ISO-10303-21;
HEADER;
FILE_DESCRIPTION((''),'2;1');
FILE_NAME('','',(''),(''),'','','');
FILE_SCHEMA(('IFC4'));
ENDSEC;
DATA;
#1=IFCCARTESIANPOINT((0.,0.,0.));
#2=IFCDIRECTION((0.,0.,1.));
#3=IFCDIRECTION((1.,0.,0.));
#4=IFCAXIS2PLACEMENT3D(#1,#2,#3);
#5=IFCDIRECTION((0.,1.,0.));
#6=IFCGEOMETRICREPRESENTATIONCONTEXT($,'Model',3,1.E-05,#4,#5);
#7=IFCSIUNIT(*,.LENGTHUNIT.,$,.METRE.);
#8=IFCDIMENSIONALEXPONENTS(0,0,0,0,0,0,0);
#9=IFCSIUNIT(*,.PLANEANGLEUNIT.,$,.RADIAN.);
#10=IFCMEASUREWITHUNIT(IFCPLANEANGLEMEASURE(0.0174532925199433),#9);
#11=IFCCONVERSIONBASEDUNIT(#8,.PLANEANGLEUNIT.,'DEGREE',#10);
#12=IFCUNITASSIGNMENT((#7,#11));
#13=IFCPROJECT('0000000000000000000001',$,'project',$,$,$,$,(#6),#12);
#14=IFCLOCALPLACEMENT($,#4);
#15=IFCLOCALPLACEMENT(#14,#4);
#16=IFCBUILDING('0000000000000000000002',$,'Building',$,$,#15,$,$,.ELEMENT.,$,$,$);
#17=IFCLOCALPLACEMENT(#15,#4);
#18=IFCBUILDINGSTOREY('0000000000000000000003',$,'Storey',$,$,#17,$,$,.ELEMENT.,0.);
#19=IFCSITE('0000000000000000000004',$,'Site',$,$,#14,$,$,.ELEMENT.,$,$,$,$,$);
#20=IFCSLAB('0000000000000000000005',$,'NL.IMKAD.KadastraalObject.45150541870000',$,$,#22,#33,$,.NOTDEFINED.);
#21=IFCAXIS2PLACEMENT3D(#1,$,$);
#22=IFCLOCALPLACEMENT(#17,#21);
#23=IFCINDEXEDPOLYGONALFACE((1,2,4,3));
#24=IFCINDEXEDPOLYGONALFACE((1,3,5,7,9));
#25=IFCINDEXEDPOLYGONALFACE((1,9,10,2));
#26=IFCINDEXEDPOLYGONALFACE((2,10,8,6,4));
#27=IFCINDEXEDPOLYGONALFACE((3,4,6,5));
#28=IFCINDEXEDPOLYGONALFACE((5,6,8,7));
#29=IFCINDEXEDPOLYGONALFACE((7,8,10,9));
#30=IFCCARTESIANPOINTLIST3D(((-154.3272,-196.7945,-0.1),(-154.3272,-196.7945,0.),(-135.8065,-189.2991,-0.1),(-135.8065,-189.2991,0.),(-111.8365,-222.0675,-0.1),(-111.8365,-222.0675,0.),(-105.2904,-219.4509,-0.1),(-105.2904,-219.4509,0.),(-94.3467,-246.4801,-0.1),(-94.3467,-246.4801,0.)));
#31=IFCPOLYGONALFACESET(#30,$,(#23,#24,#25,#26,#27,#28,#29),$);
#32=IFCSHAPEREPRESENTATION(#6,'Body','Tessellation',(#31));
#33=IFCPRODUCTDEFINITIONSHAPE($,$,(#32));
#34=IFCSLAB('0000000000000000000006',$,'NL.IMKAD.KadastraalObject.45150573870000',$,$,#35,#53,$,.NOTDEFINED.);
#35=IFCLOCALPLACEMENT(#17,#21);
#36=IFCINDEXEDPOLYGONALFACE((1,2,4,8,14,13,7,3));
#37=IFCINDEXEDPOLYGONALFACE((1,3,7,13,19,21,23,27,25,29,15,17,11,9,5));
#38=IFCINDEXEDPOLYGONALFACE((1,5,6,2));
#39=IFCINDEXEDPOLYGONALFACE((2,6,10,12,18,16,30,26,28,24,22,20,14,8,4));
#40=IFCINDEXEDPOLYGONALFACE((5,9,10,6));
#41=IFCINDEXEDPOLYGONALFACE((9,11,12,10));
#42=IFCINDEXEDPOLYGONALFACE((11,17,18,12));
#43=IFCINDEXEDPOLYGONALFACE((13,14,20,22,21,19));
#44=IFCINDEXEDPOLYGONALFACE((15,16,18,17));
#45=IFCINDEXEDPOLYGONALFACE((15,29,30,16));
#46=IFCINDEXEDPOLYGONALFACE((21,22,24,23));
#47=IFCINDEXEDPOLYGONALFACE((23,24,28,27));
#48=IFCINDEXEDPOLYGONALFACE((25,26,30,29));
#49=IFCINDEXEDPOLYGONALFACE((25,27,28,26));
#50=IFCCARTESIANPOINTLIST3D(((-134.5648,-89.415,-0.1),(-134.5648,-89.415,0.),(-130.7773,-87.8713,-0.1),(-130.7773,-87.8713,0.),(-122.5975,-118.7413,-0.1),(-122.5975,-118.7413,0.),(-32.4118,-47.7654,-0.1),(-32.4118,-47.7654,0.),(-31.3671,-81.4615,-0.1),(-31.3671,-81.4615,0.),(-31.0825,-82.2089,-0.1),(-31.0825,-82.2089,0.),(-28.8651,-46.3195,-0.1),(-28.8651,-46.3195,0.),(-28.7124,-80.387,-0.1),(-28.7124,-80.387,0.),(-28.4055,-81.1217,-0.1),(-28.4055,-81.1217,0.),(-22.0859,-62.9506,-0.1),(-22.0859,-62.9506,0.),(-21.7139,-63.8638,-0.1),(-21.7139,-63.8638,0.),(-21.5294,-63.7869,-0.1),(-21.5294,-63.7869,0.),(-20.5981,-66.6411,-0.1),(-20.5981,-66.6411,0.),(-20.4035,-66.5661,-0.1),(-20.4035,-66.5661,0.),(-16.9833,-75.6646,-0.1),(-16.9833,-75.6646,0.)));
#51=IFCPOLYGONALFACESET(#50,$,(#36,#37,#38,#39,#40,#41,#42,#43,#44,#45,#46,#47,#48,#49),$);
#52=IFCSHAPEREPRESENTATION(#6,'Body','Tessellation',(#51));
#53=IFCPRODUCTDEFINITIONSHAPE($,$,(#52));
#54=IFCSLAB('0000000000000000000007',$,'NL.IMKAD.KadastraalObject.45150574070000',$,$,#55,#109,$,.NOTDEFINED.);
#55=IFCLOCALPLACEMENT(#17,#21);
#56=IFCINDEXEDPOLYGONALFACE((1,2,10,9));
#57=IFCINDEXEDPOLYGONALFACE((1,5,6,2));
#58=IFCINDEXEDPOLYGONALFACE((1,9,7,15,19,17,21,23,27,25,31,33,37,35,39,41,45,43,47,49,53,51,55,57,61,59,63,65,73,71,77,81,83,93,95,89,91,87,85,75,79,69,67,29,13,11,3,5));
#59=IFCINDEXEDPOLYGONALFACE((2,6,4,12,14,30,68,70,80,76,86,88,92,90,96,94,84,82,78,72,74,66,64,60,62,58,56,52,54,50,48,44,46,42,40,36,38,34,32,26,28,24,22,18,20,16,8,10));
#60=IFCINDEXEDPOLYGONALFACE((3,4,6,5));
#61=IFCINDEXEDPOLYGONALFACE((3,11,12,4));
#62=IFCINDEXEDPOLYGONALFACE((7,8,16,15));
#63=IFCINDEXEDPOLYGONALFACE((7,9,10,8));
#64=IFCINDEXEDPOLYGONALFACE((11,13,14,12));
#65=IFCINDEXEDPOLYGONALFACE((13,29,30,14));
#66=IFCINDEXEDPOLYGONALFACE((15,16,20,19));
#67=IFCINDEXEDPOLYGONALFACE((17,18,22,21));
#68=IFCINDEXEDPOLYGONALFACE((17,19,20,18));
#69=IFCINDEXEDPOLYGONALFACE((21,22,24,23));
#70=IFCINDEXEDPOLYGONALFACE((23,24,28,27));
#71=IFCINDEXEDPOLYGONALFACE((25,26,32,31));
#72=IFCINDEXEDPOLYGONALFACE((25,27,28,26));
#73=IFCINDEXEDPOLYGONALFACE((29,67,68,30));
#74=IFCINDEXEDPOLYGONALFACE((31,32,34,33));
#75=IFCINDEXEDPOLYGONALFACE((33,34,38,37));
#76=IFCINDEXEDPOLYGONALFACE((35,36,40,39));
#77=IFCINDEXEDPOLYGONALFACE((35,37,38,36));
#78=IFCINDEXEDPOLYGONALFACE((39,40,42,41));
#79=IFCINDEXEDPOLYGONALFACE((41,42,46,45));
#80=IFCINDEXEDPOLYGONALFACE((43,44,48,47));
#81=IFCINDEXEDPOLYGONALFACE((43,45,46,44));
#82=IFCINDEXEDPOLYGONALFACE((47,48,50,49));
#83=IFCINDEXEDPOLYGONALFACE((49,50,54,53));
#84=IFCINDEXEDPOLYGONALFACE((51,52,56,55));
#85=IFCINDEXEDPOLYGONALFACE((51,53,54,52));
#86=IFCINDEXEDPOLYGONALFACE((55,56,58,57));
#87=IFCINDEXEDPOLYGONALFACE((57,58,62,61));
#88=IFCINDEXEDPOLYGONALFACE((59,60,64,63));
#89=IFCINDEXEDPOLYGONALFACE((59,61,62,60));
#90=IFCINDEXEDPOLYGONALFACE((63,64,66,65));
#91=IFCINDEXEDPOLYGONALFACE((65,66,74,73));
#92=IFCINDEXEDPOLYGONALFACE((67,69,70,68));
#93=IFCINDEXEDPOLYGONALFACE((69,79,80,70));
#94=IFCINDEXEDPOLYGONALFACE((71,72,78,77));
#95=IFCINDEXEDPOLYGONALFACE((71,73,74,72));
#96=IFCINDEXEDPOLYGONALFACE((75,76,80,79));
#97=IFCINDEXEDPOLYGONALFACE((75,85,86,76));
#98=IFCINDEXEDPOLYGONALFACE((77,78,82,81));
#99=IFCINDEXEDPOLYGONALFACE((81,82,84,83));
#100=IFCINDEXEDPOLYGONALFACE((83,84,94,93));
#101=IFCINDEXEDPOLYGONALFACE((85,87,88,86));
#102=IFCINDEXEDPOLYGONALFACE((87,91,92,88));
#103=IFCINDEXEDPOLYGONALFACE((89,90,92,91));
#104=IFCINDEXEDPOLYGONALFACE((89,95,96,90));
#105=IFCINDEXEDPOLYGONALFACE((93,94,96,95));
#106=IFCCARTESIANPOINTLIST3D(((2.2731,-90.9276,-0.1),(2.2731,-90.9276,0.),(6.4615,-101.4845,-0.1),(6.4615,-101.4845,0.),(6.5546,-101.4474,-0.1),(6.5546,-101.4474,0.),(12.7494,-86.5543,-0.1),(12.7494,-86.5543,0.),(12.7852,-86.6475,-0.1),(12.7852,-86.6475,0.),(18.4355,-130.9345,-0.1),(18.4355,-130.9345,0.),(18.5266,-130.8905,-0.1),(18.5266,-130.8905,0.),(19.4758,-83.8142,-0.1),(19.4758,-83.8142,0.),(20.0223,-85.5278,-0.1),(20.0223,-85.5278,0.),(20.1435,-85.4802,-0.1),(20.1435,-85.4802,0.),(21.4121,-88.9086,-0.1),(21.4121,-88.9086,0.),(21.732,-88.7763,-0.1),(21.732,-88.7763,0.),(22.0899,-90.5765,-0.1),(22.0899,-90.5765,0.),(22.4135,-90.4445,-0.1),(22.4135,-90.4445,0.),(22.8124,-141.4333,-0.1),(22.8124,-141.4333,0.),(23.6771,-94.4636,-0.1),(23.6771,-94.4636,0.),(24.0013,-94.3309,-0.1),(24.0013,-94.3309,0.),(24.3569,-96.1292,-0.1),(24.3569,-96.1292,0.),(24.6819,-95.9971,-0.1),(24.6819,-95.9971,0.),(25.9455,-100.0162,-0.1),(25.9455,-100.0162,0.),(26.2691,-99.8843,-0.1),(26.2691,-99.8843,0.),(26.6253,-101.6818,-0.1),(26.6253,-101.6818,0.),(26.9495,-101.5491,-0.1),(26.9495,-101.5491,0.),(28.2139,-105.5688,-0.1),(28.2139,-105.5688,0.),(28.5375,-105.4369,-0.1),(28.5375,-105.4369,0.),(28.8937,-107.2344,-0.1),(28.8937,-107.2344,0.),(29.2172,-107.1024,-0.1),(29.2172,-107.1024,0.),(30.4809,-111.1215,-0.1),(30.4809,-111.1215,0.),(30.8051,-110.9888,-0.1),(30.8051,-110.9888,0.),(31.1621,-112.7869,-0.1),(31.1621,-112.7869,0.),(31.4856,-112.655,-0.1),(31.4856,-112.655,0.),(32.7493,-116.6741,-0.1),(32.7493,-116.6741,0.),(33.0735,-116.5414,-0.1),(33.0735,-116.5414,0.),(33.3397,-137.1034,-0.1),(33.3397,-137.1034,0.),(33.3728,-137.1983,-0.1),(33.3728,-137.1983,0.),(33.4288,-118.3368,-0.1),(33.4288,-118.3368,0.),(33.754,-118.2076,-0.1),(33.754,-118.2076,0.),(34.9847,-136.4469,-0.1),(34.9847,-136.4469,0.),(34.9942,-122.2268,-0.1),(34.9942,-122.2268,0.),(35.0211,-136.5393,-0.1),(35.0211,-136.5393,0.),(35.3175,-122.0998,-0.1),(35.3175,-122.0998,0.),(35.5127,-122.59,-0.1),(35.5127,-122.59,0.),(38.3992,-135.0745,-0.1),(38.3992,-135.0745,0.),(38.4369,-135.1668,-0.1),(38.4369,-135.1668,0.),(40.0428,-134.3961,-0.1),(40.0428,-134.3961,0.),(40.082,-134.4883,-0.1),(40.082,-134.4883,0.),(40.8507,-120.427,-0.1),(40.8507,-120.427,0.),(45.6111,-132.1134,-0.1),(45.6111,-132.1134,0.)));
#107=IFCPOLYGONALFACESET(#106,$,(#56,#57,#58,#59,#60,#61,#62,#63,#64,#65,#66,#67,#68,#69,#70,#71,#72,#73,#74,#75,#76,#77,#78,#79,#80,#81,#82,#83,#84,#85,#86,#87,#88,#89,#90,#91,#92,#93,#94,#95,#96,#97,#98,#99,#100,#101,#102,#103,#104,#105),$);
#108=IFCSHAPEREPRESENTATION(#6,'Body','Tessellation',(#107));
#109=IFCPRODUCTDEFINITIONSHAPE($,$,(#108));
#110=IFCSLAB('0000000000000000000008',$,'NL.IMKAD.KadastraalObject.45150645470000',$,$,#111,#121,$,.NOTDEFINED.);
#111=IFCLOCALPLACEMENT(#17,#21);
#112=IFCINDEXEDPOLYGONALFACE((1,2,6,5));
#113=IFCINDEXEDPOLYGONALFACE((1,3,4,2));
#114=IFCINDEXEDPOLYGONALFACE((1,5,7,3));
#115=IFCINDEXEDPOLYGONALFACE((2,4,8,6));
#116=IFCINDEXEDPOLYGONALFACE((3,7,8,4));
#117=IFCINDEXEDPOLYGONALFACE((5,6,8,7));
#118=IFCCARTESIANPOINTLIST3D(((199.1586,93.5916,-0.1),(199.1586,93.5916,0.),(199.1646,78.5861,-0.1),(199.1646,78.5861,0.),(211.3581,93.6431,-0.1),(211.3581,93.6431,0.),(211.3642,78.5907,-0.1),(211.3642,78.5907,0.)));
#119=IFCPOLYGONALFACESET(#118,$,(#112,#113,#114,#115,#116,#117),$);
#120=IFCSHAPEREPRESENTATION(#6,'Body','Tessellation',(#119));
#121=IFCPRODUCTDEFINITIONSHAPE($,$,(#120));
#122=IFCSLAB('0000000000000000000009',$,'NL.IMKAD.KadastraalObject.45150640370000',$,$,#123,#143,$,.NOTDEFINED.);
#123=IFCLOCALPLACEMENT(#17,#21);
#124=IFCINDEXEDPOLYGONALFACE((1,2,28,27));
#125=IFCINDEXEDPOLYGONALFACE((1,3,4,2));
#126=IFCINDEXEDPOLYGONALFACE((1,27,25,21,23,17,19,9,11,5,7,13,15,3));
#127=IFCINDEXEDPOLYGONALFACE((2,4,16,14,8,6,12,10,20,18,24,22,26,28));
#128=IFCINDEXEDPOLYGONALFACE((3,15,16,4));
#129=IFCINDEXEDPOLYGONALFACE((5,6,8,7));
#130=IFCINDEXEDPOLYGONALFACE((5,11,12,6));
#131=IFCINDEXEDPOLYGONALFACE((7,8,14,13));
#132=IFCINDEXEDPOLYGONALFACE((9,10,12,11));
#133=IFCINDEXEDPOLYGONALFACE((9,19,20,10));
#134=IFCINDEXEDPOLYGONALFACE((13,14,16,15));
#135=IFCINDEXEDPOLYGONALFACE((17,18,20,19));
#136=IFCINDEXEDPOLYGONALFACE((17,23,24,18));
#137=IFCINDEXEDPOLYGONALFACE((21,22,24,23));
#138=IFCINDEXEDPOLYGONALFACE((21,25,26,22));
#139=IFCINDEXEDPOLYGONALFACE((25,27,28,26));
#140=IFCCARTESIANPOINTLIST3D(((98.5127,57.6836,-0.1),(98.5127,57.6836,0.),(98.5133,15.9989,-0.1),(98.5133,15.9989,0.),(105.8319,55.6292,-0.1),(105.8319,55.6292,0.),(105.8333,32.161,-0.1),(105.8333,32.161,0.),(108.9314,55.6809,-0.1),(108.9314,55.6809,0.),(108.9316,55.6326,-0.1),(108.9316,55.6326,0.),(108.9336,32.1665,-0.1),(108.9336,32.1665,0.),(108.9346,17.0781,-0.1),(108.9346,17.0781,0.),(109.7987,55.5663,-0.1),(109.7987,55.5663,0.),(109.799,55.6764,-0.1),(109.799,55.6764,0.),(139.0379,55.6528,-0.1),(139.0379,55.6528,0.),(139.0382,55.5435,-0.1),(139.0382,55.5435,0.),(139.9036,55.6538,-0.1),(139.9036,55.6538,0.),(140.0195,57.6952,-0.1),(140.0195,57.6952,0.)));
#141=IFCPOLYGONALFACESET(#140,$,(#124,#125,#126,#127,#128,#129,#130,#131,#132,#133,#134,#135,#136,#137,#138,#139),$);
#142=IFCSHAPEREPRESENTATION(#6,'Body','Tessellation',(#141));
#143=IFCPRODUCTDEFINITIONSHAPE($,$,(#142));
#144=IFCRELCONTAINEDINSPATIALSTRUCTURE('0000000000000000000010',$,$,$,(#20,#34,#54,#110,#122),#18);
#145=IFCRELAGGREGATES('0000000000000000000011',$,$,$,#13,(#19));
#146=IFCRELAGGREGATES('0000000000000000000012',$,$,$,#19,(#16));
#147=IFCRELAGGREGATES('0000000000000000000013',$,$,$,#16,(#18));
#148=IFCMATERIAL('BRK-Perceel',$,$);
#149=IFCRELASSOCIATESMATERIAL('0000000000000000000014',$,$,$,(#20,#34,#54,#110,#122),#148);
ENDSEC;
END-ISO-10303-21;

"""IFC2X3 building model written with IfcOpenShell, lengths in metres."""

from ifc_helpers import new_model, entity, si_unit, converted_unit, direction, frame, origin_with_axes, place, context, project, spatial, polyline, outline, extrude, material, element, save


model = new_model("IFC2X3")

# Units and contexts
model_context = context("Model", 3, precision=1e-05, world=origin_with_axes(), true_north=direction((0.0, 1.0, 0.0)))
ifc_project = project(units=[si_unit("LENGTHUNIT", "METRE"), converted_unit("PLANEANGLEUNIT", "DEGREE", entity("IfcPlaneAngleMeasure", 0.0174532925199433), si_unit("PLANEANGLEUNIT", "RADIAN"), dimensions=[0, 0, 0, 0, 0, 0, 0])], contexts=[model_context])

# Site, building, storey
site_placement = place(None, origin_with_axes())
site = spatial("IfcSite", under=ifc_project, at=site_placement, Name="Site", CompositionType="ELEMENT")
building_placement = place(site_placement, origin_with_axes())
building = spatial("IfcBuilding", under=site, at=building_placement, Name="Building", CompositionType="ELEMENT")
storey_placement = place(building_placement, origin_with_axes())
storey = spatial("IfcBuildingStorey", under=building, at=storey_placement, Name="Storey", CompositionType="ELEMENT", Elevation=0.0)

# Slabs
ifc_material = material(Name="BRK-Perceel")
slab_1_placement = place(storey_placement, frame((0.0, 0.0, -0.1), z_axis=(0.0, 0.0, 1.0), x_axis=(1.0, 0.0, 0.0)))
element("IfcSlab", 1, at=slab_1_placement, inside=storey, material=ifc_material, Name="NL.IMKAD.KadastraalObject.45150541870000", PredefinedType="NOTDEFINED", context=model_context, shape_type="SweptSolid", body=[
    extrude(outline(polyline([(-135.8065, -189.2991), (-111.8365, -222.0675), (-105.2904, -219.4509), (-94.3467, -246.4801), (-154.3272, -196.7945), (-135.8065, -189.2991)])), origin_with_axes(), (0.0, 0.0, 1.0), 0.1),
])
slab_2_placement = place(storey_placement, frame((0.0, 0.0, -0.1), z_axis=(0.0, 0.0, 1.0), x_axis=(1.0, 0.0, 0.0)))
element("IfcSlab", 2, at=slab_2_placement, inside=storey, material=ifc_material, Name="NL.IMKAD.KadastraalObject.45150573870000", PredefinedType="NOTDEFINED", context=model_context, shape_type="SweptSolid", body=[
    extrude(outline(polyline([(-22.0859, -62.9506), (-21.7139, -63.8638), (-21.5294, -63.7869), (-20.4035, -66.5661), (-20.5981, -66.6411), (-16.9833, -75.6646), (-28.7124, -80.387), (-28.4055, -81.1217), (-31.0825, -82.2089), (-31.3671, -81.4615), (-122.5975, -118.7413), (-134.5648, -89.415), (-130.7773, -87.8713), (-32.4118, -47.7654), (-28.8651, -46.3195), (-22.0859, -62.9506)])), origin_with_axes(), (0.0, 0.0, 1.0), 0.1),
])
slab_3_placement = place(storey_placement, frame((0.0, 0.0, -0.1), z_axis=(0.0, 0.0, 1.0), x_axis=(1.0, 0.0, 0.0)))
element("IfcSlab", 3, at=slab_3_placement, inside=storey, material=ifc_material, Name="NL.IMKAD.KadastraalObject.45150574070000", PredefinedType="NOTDEFINED", context=model_context, shape_type="SweptSolid", body=[
    extrude(outline(polyline([(33.4288, -118.3368), (34.9942, -122.2268), (35.3175, -122.0998), (35.5127, -122.59), (40.8507, -120.427), (45.6111, -132.1134), (40.0428, -134.3961), (40.082, -134.4883), (38.4369, -135.1668), (38.3992, -135.0745), (34.9847, -136.4469), (35.0211, -136.5393), (33.3728, -137.1983), (33.3397, -137.1034), (22.8124, -141.4333), (18.5266, -130.8905), (18.4355, -130.9345), (6.4615, -101.4845), (6.5546, -101.4474), (2.2731, -90.9276), (12.7852, -86.6475), (12.7494, -86.5543), (19.4758, -83.8142), (20.1435, -85.4802), (20.0223, -85.5278), (21.4121, -88.9086), (21.732, -88.7763), (22.4135, -90.4445), (22.0899, -90.5765), (23.6771, -94.4636), (24.0013, -94.3309), (24.6819, -95.9971), (24.3569, -96.1292), (25.9455, -100.0162), (26.2691, -99.8843), (26.9495, -101.5491), (26.6253, -101.6818), (28.2139, -105.5688), (28.5375, -105.4369), (29.2172, -107.1024), (28.8937, -107.2344), (30.4809, -111.1215), (30.8051, -110.9888), (31.4856, -112.655), (31.1621, -112.7869), (32.7493, -116.6741), (33.0735, -116.5414), (33.754, -118.2076), (33.4288, -118.3368)])), origin_with_axes(), (0.0, 0.0, 1.0), 0.1),
])
slab_4_placement = place(storey_placement, frame((0.0, 0.0, -0.1), z_axis=(0.0, 0.0, 1.0), x_axis=(1.0, 0.0, 0.0)))
element("IfcSlab", 4, at=slab_4_placement, inside=storey, material=ifc_material, Name="NL.IMKAD.KadastraalObject.45150645470000", PredefinedType="NOTDEFINED", context=model_context, shape_type="SweptSolid", body=[
    extrude(outline(polyline([(211.3581, 93.6431), (211.3642, 78.5907), (199.1646, 78.5861), (199.1586, 93.5916), (211.3581, 93.6431)])), origin_with_axes(), (0.0, 0.0, 1.0), 0.1),
])
slab_5_placement = place(storey_placement, frame((0.0, 0.0, -0.1), z_axis=(0.0, 0.0, 1.0), x_axis=(1.0, 0.0, 0.0)))
element("IfcSlab", 5, at=slab_5_placement, inside=storey, material=ifc_material, Name="NL.IMKAD.KadastraalObject.45150640370000", PredefinedType="NOTDEFINED", context=model_context, shape_type="SweptSolid", body=[
    extrude(outline(polyline([(98.5133, 15.9989), (98.5127, 57.6836), (140.0195, 57.6952), (139.9036, 55.6538), (139.0379, 55.6528), (139.0382, 55.5435), (109.7987, 55.5663), (109.799, 55.6764), (108.9314, 55.6809), (108.9316, 55.6326), (105.8319, 55.6292), (105.8333, 32.161), (108.9336, 32.1665), (108.9346, 17.0781), (98.5133, 15.9989)])), origin_with_axes(), (0.0, 0.0, 1.0), 0.1),
])

save(model, "model.ifc")
